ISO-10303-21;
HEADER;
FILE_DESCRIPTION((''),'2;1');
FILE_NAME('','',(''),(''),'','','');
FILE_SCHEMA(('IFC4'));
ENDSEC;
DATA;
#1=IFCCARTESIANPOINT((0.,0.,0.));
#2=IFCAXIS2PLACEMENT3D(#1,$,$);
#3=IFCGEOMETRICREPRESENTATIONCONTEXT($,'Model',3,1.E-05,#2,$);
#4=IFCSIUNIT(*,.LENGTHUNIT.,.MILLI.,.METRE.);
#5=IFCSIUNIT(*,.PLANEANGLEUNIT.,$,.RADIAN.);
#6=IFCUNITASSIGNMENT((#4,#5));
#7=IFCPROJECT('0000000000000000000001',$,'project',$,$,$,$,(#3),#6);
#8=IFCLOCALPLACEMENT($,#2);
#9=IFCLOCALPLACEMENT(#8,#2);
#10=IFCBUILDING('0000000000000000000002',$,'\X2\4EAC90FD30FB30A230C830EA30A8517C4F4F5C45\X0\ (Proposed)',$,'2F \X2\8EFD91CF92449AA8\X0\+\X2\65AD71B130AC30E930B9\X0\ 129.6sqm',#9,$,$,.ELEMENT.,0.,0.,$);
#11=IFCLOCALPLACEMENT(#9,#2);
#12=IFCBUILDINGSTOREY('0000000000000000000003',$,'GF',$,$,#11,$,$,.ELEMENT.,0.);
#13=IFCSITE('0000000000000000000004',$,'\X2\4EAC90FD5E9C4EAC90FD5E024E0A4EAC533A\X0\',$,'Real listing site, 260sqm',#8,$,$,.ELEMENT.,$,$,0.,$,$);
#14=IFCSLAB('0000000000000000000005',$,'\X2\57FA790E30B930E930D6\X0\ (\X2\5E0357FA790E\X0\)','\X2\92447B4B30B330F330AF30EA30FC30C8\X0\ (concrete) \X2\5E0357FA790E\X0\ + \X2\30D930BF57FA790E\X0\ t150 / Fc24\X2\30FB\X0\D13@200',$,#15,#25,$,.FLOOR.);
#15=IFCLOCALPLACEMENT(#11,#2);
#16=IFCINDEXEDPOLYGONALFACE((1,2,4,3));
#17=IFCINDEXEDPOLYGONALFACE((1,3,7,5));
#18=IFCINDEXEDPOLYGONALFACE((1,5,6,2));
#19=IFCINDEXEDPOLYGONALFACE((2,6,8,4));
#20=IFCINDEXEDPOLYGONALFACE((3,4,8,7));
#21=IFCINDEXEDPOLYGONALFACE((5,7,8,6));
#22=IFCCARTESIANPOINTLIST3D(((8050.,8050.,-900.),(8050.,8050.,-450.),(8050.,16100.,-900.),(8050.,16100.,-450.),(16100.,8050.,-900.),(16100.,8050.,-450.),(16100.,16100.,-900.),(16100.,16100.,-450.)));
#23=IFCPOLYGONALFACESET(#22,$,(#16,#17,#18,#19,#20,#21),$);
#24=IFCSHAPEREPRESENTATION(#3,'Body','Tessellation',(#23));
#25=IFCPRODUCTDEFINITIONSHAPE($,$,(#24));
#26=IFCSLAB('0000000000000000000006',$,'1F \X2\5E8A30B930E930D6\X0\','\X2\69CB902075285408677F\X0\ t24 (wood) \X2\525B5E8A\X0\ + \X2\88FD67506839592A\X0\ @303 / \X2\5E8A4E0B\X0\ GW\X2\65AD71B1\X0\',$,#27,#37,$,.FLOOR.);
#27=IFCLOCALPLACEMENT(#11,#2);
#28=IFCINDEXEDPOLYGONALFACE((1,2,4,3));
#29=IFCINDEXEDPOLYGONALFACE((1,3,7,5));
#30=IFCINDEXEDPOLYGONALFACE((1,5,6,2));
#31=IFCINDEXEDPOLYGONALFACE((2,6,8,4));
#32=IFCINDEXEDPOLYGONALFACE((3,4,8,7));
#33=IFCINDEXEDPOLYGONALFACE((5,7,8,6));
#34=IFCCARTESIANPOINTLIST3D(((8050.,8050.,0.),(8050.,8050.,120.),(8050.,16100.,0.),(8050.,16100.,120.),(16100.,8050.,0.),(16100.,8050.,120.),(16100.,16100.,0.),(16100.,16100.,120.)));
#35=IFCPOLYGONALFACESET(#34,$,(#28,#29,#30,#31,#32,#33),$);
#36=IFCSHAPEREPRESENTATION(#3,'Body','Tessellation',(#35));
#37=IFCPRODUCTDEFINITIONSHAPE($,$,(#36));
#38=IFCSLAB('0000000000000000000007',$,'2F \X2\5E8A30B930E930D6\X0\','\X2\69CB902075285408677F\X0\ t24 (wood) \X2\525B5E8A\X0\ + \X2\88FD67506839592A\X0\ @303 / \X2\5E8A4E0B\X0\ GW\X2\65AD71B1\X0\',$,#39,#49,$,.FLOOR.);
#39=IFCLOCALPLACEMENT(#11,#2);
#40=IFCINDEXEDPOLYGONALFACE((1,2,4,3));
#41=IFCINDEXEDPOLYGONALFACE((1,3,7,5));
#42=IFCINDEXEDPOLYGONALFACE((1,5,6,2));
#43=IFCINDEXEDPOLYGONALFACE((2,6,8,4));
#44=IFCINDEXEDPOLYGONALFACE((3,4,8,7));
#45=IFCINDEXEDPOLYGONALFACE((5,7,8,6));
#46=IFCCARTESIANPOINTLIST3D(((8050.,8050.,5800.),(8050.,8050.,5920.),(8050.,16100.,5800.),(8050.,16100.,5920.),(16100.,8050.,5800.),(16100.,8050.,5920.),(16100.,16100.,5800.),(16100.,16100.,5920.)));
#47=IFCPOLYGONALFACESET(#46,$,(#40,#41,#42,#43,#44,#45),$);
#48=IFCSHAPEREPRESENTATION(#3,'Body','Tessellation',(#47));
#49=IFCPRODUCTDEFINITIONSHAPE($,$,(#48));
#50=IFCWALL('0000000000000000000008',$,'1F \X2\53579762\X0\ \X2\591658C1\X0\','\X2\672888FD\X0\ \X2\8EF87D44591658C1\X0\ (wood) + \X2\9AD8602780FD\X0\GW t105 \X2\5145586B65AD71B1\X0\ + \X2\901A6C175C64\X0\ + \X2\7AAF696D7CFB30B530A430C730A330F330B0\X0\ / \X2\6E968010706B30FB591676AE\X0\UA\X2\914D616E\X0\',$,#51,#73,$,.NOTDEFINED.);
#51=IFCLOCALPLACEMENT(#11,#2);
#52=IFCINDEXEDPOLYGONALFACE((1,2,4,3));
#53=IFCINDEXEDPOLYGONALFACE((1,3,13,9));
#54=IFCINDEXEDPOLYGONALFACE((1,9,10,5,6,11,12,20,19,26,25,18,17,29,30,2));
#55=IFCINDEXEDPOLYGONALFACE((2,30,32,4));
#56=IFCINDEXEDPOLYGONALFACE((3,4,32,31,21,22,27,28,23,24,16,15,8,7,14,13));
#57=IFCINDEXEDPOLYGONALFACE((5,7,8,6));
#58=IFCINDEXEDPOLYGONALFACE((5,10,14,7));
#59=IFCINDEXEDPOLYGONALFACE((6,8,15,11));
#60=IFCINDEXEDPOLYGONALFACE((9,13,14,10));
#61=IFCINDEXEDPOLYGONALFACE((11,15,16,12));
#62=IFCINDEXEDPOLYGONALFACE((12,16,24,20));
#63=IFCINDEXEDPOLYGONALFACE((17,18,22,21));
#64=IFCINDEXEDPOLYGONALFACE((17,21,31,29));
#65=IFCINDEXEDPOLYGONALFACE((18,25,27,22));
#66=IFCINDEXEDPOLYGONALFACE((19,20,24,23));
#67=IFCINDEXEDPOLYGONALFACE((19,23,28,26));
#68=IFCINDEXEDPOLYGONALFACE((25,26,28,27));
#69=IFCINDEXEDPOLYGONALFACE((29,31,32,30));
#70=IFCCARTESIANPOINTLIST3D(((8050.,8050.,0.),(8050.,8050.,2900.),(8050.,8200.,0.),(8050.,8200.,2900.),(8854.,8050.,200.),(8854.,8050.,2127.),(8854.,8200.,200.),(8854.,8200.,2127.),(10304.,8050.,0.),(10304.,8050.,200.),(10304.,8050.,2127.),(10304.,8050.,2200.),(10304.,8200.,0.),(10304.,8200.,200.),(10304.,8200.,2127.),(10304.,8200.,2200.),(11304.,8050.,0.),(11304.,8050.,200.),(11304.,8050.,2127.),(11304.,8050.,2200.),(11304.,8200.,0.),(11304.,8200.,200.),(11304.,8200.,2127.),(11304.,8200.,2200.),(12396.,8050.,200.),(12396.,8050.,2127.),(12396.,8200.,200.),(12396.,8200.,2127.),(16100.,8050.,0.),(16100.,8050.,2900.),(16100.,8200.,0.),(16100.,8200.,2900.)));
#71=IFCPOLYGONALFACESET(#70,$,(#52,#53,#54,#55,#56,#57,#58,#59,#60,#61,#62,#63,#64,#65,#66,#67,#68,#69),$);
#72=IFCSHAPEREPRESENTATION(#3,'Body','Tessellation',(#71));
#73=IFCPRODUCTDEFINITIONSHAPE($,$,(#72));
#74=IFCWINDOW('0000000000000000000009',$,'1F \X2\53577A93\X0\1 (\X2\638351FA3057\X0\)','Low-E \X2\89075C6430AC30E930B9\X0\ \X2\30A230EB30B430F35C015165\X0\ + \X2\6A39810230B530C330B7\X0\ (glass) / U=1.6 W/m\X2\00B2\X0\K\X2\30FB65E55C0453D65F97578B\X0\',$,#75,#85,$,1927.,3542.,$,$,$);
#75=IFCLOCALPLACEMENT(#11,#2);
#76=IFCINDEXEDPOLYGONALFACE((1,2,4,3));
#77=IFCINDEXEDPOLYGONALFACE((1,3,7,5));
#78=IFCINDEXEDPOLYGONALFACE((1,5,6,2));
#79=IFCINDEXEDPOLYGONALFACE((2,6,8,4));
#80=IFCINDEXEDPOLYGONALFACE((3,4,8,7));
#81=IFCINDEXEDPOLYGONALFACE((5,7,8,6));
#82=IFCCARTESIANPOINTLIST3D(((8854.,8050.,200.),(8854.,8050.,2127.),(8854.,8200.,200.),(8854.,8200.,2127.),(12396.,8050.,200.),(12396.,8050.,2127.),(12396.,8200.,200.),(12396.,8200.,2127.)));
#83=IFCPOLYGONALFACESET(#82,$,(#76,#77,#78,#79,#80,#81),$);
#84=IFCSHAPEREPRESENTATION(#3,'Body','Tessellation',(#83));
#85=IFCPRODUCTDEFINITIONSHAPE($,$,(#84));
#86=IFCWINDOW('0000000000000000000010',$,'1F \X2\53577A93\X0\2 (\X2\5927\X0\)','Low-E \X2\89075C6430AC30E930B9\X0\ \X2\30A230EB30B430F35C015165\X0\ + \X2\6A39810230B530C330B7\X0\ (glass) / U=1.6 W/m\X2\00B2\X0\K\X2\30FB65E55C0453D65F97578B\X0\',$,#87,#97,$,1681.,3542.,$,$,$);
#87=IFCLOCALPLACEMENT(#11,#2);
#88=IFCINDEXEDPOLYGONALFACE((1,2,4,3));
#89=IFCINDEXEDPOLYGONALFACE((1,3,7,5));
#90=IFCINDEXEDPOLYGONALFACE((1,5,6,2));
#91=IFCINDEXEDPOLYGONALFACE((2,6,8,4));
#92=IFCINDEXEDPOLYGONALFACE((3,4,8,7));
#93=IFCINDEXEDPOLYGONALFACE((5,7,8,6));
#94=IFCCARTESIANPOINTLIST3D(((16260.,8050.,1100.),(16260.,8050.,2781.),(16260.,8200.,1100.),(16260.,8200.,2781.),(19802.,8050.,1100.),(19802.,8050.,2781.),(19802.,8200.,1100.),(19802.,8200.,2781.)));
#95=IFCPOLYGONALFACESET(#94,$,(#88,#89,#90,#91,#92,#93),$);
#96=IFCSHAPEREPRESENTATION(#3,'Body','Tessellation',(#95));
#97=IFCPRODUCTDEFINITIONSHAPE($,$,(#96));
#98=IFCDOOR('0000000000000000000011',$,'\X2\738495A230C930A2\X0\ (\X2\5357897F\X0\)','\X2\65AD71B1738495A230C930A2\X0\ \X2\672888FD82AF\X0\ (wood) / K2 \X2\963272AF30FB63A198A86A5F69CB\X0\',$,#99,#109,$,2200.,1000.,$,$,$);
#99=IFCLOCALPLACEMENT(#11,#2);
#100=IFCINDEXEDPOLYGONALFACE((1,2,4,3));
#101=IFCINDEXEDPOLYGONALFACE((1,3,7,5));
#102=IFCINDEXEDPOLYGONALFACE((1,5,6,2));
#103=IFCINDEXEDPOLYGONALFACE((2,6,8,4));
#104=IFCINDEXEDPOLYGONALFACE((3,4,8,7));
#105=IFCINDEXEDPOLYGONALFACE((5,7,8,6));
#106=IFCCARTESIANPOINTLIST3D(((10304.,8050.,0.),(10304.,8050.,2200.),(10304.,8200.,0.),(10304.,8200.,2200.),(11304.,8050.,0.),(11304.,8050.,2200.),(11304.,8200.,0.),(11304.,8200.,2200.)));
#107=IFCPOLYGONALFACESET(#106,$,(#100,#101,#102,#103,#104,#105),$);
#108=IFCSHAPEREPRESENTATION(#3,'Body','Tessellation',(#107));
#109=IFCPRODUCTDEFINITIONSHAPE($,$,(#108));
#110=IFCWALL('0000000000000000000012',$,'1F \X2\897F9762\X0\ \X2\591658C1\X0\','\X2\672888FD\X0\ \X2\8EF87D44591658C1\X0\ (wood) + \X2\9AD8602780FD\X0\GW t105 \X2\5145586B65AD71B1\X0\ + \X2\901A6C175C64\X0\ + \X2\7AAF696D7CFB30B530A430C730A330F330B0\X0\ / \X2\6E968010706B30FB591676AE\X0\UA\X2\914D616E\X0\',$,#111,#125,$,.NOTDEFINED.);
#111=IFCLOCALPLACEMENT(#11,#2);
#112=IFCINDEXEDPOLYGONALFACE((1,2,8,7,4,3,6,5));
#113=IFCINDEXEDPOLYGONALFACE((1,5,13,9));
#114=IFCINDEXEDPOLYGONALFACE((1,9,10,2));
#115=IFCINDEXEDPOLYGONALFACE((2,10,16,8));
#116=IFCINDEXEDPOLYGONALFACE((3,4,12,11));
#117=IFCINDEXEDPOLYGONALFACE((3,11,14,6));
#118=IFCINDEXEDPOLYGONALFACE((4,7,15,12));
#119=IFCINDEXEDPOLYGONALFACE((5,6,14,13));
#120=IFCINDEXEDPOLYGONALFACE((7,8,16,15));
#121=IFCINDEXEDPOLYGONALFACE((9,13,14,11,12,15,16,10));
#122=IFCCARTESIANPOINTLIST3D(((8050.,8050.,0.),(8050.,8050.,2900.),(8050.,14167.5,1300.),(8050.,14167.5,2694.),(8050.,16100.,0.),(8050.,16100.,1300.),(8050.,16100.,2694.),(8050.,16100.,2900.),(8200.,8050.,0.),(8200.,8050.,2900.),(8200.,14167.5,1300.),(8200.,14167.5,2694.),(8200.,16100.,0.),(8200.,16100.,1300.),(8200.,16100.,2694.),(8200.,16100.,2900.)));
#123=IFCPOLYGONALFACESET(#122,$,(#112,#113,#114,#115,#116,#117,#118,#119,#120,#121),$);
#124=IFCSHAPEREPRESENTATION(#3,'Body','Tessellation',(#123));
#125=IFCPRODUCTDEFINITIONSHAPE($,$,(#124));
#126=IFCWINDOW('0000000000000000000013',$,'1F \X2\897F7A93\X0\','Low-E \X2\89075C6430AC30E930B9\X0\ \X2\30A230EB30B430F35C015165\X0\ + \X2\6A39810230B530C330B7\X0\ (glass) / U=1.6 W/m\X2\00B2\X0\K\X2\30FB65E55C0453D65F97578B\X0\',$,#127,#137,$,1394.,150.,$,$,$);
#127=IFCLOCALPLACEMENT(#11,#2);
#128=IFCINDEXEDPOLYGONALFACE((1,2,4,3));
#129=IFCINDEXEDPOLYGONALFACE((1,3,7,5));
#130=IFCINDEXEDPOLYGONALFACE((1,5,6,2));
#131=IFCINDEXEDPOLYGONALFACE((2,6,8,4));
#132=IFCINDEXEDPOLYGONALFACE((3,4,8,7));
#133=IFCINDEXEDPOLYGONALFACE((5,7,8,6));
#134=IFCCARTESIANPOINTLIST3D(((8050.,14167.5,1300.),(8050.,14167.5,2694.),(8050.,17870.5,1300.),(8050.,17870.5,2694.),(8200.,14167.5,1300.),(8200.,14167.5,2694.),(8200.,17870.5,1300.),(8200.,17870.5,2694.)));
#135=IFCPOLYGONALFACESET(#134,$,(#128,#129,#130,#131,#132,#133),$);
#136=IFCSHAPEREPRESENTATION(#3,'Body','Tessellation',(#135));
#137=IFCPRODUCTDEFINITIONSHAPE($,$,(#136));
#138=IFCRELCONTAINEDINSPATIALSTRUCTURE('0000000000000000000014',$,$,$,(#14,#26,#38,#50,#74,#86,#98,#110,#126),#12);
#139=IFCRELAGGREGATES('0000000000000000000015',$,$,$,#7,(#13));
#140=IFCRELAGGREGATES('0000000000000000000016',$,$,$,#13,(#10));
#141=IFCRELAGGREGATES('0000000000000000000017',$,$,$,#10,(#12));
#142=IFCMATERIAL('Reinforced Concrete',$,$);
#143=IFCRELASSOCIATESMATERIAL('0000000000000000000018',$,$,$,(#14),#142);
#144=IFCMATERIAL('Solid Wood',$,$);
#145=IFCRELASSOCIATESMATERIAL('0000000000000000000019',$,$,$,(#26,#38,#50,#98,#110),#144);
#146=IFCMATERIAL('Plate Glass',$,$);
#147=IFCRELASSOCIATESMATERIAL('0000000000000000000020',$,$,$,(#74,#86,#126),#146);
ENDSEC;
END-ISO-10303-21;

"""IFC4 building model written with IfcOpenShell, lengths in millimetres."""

from ifc_helpers import new_model, si_unit, frame, frame_2d, origin, place, context, project, spatial, rectangle, extrude, material, element, fill, save


model = new_model("IFC4")

# Units and contexts
model_context = context("Model", 3, precision=1e-05, world=origin())
ifc_project = project(units=[si_unit("LENGTHUNIT", "METRE", prefix="MILLI"), si_unit("PLANEANGLEUNIT", "RADIAN")], contexts=[model_context])

# Site, building, storey
site_placement = place(None, origin())
site = spatial("IfcSite", under=ifc_project, at=site_placement, Name="京都府京都市上京区", ObjectType="Real listing site, 260sqm", CompositionType="ELEMENT", RefElevation=0.0)
building_placement = place(site_placement, origin())
building = spatial("IfcBuilding", under=site, at=building_placement, Name="京都・アトリエ兼住居 (Proposed)", ObjectType="2F 軽量鉄骨+断熱ガラス 129.6sqm", CompositionType="ELEMENT", ElevationOfRefHeight=0.0, ElevationOfTerrain=0.0)
storey_placement = place(building_placement, origin())
storey = spatial("IfcBuildingStorey", under=building, at=storey_placement, Name="GF", CompositionType="ELEMENT", Elevation=0.0)

# Shared definitions
ifc_material_1 = material(Name="Solid Wood")

# Slabs
ifc_material_2 = material(Name="Reinforced Concrete")
slab_1_placement = place(storey_placement, frame((4025.0, 4025.0, -450.0)))
element("IfcSlab", 1, at=slab_1_placement, inside=storey, material=ifc_material_2, Name="基礎スラブ (布基礎)", Description="鉄筋コンクリート (concrete) 布基礎 + ベタ基礎 t150 / Fc24・D13@200", PredefinedType="FLOOR", context=model_context, shape_type="SweptSolid", body=[
    extrude(rectangle(XDim=8050.0, YDim=8050.0, at=frame_2d((4025.0, 4025.0))), frame((4025.0, 4025.0, -450.0)), (0.0, 0.0, 1.0), 450.0),
])
slab_2_placement = place(storey_placement, frame((4025.0, 4025.0, 0.0)))
element("IfcSlab", 2, at=slab_2_placement, inside=storey, material=ifc_material_1, Name="1F 床スラブ", Description="構造用合板 t24 (wood) 剛床 + 製材根太 @303 / 床下 GW断熱", PredefinedType="FLOOR", context=model_context, shape_type="SweptSolid", body=[
    extrude(rectangle(XDim=8050.0, YDim=8050.0, at=frame_2d((4025.0, 4025.0))), frame((4025.0, 4025.0, 0.0)), (0.0, 0.0, 1.0), 120.0),
])
slab_3_placement = place(storey_placement, frame((4025.0, 4025.0, 2900.0)))
element("IfcSlab", 3, at=slab_3_placement, inside=storey, material=ifc_material_1, Name="2F 床スラブ", Description="構造用合板 t24 (wood) 剛床 + 製材根太 @303 / 床下 GW断熱", PredefinedType="FLOOR", context=model_context, shape_type="SweptSolid", body=[
    extrude(rectangle(XDim=8050.0, YDim=8050.0, at=frame_2d((4025.0, 4025.0))), frame((4025.0, 4025.0, 2900.0)), (0.0, 0.0, 1.0), 120.0),
])

# Wall, openings, windows, door
wall_1_placement = place(storey_placement, frame((4025.0, 4025.0, 0.0)))
wall_1 = element("IfcWall", 4, at=wall_1_placement, inside=storey, material=ifc_material_1, Name="1F 南面 外壁", Description="木製 軸組外壁 (wood) + 高性能GW t105 充填断熱 + 通気層 + 窯業系サイディング / 準耐火・外皮UA配慮", PredefinedType="NOTDEFINED", context=model_context, shape_type="SweptSolid", body=[
    extrude(rectangle(XDim=8050.0, YDim=150.0, at=frame_2d((4025.0, 75.0))), frame((4025.0, 4025.0, 0.0)), (0.0, 0.0, 1.0), 2900.0),
])
opening_1_placement = place(storey_placement, frame((4427.0, 4025.0, 100.0)))
opening_1 = element("IfcOpeningElement", 5, at=opening_1_placement, cuts=wall_1, PredefinedType="NOTDEFINED", context=model_context, shape_type="SweptSolid", body=[
    extrude(rectangle(XDim=3542.0, YDim=150.0, at=frame_2d((1771.0, 75.0))), frame((4427.0, 4025.0, 100.0)), (0.0, 0.0, 1.0), 1927.0),
])
opening_2_placement = place(storey_placement, frame((8130.0, 4025.0, 550.0)))
opening_2 = element("IfcOpeningElement", 6, at=opening_2_placement, cuts=wall_1, PredefinedType="NOTDEFINED", context=model_context, shape_type="SweptSolid", body=[
    extrude(rectangle(XDim=3542.0, YDim=150.0, at=frame_2d((1771.0, 75.0))), frame((8130.0, 4025.0, 550.0)), (0.0, 0.0, 1.0), 1681.0),
])
opening_3_placement = place(storey_placement, frame((5152.0, 4025.0, 0.0)))
opening_3 = element("IfcOpeningElement", 7, at=opening_3_placement, cuts=wall_1, PredefinedType="NOTDEFINED", context=model_context, shape_type="SweptSolid", body=[
    extrude(rectangle(XDim=1000.0, YDim=150.0, at=frame_2d((500.0, 75.0))), frame((5152.0, 4025.0, 0.0)), (0.0, 0.0, 1.0), 2200.0),
])
ifc_material_3 = material(Name="Plate Glass")
window_1_placement = place(storey_placement, frame((4427.0, 4025.0, 100.0)))
window_1 = element("IfcWindow", 8, at=window_1_placement, inside=storey, material=ifc_material_3, Name="1F 南窓1 (掃出し)", Description="Low-E 複層ガラス アルゴン封入 + 樹脂サッシ (glass) / U=1.6 W/m²K・日射取得型", OverallHeight=1927.0, OverallWidth=3542.0, context=model_context, shape_type="SweptSolid", body=[
    extrude(rectangle(XDim=3542.0, YDim=150.0, at=frame_2d((1771.0, 75.0))), frame((4427.0, 4025.0, 100.0)), (0.0, 0.0, 1.0), 1927.0),
])
fill(opening_1, window_1)
window_2_placement = place(storey_placement, frame((8130.0, 4025.0, 550.0)))
window_2 = element("IfcWindow", 9, at=window_2_placement, inside=storey, material=ifc_material_3, Name="1F 南窓2 (大)", Description="Low-E 複層ガラス アルゴン封入 + 樹脂サッシ (glass) / U=1.6 W/m²K・日射取得型", OverallHeight=1681.0, OverallWidth=3542.0, context=model_context, shape_type="SweptSolid", body=[
    extrude(rectangle(XDim=3542.0, YDim=150.0, at=frame_2d((1771.0, 75.0))), frame((8130.0, 4025.0, 550.0)), (0.0, 0.0, 1.0), 1681.0),
])
fill(opening_2, window_2)
door_placement = place(storey_placement, frame((5152.0, 4025.0, 0.0)))
door = element("IfcDoor", 10, at=door_placement, inside=storey, material=ifc_material_1, Name="玄関ドア (南西)", Description="断熱玄関ドア 木製芯 (wood) / K2 防犯・採風機構", OverallHeight=2200.0, OverallWidth=1000.0, context=model_context, shape_type="SweptSolid", body=[
    extrude(rectangle(XDim=1000.0, YDim=150.0, at=frame_2d((500.0, 75.0))), frame((5152.0, 4025.0, 0.0)), (0.0, 0.0, 1.0), 2200.0),
])
fill(opening_3, door)

# Wall, opening, window
wall_2_placement = place(storey_placement, frame((4025.0, 4025.0, 0.0)))
wall_2 = element("IfcWall", 11, at=wall_2_placement, inside=storey, material=ifc_material_1, Name="1F 西面 外壁", Description="木製 軸組外壁 (wood) + 高性能GW t105 充填断熱 + 通気層 + 窯業系サイディング / 準耐火・外皮UA配慮", PredefinedType="NOTDEFINED", context=model_context, shape_type="SweptSolid", body=[
    extrude(rectangle(XDim=150.0, YDim=8050.0, at=frame_2d((75.0, 4025.0))), frame((4025.0, 4025.0, 0.0)), (0.0, 0.0, 1.0), 2900.0),
])
opening_4_placement = place(storey_placement, frame((4025.0, 7084.0, 650.0)))
opening_4 = element("IfcOpeningElement", 12, at=opening_4_placement, cuts=wall_2, PredefinedType="NOTDEFINED", context=model_context, shape_type="SweptSolid", body=[
    extrude(rectangle(XDim=150.0, YDim=3703.0, at=frame_2d((75.0, 1851.0))), frame((4025.0, 7084.0, 650.0)), (0.0, 0.0, 1.0), 1394.0),
])
window_3_placement = place(storey_placement, frame((4025.0, 7084.0, 650.0)))
window_3 = element("IfcWindow", 13, at=window_3_placement, inside=storey, material=ifc_material_3, Name="1F 西窓", Description="Low-E 複層ガラス アルゴン封入 + 樹脂サッシ (glass) / U=1.6 W/m²K・日射取得型", OverallHeight=1394.0, OverallWidth=150.0, context=model_context, shape_type="SweptSolid", body=[
    extrude(rectangle(XDim=150.0, YDim=3703.0, at=frame_2d((75.0, 1851.0))), frame((4025.0, 7084.0, 650.0)), (0.0, 0.0, 1.0), 1394.0),
])
fill(opening_4, window_3)

save(model, "model.ifc")
